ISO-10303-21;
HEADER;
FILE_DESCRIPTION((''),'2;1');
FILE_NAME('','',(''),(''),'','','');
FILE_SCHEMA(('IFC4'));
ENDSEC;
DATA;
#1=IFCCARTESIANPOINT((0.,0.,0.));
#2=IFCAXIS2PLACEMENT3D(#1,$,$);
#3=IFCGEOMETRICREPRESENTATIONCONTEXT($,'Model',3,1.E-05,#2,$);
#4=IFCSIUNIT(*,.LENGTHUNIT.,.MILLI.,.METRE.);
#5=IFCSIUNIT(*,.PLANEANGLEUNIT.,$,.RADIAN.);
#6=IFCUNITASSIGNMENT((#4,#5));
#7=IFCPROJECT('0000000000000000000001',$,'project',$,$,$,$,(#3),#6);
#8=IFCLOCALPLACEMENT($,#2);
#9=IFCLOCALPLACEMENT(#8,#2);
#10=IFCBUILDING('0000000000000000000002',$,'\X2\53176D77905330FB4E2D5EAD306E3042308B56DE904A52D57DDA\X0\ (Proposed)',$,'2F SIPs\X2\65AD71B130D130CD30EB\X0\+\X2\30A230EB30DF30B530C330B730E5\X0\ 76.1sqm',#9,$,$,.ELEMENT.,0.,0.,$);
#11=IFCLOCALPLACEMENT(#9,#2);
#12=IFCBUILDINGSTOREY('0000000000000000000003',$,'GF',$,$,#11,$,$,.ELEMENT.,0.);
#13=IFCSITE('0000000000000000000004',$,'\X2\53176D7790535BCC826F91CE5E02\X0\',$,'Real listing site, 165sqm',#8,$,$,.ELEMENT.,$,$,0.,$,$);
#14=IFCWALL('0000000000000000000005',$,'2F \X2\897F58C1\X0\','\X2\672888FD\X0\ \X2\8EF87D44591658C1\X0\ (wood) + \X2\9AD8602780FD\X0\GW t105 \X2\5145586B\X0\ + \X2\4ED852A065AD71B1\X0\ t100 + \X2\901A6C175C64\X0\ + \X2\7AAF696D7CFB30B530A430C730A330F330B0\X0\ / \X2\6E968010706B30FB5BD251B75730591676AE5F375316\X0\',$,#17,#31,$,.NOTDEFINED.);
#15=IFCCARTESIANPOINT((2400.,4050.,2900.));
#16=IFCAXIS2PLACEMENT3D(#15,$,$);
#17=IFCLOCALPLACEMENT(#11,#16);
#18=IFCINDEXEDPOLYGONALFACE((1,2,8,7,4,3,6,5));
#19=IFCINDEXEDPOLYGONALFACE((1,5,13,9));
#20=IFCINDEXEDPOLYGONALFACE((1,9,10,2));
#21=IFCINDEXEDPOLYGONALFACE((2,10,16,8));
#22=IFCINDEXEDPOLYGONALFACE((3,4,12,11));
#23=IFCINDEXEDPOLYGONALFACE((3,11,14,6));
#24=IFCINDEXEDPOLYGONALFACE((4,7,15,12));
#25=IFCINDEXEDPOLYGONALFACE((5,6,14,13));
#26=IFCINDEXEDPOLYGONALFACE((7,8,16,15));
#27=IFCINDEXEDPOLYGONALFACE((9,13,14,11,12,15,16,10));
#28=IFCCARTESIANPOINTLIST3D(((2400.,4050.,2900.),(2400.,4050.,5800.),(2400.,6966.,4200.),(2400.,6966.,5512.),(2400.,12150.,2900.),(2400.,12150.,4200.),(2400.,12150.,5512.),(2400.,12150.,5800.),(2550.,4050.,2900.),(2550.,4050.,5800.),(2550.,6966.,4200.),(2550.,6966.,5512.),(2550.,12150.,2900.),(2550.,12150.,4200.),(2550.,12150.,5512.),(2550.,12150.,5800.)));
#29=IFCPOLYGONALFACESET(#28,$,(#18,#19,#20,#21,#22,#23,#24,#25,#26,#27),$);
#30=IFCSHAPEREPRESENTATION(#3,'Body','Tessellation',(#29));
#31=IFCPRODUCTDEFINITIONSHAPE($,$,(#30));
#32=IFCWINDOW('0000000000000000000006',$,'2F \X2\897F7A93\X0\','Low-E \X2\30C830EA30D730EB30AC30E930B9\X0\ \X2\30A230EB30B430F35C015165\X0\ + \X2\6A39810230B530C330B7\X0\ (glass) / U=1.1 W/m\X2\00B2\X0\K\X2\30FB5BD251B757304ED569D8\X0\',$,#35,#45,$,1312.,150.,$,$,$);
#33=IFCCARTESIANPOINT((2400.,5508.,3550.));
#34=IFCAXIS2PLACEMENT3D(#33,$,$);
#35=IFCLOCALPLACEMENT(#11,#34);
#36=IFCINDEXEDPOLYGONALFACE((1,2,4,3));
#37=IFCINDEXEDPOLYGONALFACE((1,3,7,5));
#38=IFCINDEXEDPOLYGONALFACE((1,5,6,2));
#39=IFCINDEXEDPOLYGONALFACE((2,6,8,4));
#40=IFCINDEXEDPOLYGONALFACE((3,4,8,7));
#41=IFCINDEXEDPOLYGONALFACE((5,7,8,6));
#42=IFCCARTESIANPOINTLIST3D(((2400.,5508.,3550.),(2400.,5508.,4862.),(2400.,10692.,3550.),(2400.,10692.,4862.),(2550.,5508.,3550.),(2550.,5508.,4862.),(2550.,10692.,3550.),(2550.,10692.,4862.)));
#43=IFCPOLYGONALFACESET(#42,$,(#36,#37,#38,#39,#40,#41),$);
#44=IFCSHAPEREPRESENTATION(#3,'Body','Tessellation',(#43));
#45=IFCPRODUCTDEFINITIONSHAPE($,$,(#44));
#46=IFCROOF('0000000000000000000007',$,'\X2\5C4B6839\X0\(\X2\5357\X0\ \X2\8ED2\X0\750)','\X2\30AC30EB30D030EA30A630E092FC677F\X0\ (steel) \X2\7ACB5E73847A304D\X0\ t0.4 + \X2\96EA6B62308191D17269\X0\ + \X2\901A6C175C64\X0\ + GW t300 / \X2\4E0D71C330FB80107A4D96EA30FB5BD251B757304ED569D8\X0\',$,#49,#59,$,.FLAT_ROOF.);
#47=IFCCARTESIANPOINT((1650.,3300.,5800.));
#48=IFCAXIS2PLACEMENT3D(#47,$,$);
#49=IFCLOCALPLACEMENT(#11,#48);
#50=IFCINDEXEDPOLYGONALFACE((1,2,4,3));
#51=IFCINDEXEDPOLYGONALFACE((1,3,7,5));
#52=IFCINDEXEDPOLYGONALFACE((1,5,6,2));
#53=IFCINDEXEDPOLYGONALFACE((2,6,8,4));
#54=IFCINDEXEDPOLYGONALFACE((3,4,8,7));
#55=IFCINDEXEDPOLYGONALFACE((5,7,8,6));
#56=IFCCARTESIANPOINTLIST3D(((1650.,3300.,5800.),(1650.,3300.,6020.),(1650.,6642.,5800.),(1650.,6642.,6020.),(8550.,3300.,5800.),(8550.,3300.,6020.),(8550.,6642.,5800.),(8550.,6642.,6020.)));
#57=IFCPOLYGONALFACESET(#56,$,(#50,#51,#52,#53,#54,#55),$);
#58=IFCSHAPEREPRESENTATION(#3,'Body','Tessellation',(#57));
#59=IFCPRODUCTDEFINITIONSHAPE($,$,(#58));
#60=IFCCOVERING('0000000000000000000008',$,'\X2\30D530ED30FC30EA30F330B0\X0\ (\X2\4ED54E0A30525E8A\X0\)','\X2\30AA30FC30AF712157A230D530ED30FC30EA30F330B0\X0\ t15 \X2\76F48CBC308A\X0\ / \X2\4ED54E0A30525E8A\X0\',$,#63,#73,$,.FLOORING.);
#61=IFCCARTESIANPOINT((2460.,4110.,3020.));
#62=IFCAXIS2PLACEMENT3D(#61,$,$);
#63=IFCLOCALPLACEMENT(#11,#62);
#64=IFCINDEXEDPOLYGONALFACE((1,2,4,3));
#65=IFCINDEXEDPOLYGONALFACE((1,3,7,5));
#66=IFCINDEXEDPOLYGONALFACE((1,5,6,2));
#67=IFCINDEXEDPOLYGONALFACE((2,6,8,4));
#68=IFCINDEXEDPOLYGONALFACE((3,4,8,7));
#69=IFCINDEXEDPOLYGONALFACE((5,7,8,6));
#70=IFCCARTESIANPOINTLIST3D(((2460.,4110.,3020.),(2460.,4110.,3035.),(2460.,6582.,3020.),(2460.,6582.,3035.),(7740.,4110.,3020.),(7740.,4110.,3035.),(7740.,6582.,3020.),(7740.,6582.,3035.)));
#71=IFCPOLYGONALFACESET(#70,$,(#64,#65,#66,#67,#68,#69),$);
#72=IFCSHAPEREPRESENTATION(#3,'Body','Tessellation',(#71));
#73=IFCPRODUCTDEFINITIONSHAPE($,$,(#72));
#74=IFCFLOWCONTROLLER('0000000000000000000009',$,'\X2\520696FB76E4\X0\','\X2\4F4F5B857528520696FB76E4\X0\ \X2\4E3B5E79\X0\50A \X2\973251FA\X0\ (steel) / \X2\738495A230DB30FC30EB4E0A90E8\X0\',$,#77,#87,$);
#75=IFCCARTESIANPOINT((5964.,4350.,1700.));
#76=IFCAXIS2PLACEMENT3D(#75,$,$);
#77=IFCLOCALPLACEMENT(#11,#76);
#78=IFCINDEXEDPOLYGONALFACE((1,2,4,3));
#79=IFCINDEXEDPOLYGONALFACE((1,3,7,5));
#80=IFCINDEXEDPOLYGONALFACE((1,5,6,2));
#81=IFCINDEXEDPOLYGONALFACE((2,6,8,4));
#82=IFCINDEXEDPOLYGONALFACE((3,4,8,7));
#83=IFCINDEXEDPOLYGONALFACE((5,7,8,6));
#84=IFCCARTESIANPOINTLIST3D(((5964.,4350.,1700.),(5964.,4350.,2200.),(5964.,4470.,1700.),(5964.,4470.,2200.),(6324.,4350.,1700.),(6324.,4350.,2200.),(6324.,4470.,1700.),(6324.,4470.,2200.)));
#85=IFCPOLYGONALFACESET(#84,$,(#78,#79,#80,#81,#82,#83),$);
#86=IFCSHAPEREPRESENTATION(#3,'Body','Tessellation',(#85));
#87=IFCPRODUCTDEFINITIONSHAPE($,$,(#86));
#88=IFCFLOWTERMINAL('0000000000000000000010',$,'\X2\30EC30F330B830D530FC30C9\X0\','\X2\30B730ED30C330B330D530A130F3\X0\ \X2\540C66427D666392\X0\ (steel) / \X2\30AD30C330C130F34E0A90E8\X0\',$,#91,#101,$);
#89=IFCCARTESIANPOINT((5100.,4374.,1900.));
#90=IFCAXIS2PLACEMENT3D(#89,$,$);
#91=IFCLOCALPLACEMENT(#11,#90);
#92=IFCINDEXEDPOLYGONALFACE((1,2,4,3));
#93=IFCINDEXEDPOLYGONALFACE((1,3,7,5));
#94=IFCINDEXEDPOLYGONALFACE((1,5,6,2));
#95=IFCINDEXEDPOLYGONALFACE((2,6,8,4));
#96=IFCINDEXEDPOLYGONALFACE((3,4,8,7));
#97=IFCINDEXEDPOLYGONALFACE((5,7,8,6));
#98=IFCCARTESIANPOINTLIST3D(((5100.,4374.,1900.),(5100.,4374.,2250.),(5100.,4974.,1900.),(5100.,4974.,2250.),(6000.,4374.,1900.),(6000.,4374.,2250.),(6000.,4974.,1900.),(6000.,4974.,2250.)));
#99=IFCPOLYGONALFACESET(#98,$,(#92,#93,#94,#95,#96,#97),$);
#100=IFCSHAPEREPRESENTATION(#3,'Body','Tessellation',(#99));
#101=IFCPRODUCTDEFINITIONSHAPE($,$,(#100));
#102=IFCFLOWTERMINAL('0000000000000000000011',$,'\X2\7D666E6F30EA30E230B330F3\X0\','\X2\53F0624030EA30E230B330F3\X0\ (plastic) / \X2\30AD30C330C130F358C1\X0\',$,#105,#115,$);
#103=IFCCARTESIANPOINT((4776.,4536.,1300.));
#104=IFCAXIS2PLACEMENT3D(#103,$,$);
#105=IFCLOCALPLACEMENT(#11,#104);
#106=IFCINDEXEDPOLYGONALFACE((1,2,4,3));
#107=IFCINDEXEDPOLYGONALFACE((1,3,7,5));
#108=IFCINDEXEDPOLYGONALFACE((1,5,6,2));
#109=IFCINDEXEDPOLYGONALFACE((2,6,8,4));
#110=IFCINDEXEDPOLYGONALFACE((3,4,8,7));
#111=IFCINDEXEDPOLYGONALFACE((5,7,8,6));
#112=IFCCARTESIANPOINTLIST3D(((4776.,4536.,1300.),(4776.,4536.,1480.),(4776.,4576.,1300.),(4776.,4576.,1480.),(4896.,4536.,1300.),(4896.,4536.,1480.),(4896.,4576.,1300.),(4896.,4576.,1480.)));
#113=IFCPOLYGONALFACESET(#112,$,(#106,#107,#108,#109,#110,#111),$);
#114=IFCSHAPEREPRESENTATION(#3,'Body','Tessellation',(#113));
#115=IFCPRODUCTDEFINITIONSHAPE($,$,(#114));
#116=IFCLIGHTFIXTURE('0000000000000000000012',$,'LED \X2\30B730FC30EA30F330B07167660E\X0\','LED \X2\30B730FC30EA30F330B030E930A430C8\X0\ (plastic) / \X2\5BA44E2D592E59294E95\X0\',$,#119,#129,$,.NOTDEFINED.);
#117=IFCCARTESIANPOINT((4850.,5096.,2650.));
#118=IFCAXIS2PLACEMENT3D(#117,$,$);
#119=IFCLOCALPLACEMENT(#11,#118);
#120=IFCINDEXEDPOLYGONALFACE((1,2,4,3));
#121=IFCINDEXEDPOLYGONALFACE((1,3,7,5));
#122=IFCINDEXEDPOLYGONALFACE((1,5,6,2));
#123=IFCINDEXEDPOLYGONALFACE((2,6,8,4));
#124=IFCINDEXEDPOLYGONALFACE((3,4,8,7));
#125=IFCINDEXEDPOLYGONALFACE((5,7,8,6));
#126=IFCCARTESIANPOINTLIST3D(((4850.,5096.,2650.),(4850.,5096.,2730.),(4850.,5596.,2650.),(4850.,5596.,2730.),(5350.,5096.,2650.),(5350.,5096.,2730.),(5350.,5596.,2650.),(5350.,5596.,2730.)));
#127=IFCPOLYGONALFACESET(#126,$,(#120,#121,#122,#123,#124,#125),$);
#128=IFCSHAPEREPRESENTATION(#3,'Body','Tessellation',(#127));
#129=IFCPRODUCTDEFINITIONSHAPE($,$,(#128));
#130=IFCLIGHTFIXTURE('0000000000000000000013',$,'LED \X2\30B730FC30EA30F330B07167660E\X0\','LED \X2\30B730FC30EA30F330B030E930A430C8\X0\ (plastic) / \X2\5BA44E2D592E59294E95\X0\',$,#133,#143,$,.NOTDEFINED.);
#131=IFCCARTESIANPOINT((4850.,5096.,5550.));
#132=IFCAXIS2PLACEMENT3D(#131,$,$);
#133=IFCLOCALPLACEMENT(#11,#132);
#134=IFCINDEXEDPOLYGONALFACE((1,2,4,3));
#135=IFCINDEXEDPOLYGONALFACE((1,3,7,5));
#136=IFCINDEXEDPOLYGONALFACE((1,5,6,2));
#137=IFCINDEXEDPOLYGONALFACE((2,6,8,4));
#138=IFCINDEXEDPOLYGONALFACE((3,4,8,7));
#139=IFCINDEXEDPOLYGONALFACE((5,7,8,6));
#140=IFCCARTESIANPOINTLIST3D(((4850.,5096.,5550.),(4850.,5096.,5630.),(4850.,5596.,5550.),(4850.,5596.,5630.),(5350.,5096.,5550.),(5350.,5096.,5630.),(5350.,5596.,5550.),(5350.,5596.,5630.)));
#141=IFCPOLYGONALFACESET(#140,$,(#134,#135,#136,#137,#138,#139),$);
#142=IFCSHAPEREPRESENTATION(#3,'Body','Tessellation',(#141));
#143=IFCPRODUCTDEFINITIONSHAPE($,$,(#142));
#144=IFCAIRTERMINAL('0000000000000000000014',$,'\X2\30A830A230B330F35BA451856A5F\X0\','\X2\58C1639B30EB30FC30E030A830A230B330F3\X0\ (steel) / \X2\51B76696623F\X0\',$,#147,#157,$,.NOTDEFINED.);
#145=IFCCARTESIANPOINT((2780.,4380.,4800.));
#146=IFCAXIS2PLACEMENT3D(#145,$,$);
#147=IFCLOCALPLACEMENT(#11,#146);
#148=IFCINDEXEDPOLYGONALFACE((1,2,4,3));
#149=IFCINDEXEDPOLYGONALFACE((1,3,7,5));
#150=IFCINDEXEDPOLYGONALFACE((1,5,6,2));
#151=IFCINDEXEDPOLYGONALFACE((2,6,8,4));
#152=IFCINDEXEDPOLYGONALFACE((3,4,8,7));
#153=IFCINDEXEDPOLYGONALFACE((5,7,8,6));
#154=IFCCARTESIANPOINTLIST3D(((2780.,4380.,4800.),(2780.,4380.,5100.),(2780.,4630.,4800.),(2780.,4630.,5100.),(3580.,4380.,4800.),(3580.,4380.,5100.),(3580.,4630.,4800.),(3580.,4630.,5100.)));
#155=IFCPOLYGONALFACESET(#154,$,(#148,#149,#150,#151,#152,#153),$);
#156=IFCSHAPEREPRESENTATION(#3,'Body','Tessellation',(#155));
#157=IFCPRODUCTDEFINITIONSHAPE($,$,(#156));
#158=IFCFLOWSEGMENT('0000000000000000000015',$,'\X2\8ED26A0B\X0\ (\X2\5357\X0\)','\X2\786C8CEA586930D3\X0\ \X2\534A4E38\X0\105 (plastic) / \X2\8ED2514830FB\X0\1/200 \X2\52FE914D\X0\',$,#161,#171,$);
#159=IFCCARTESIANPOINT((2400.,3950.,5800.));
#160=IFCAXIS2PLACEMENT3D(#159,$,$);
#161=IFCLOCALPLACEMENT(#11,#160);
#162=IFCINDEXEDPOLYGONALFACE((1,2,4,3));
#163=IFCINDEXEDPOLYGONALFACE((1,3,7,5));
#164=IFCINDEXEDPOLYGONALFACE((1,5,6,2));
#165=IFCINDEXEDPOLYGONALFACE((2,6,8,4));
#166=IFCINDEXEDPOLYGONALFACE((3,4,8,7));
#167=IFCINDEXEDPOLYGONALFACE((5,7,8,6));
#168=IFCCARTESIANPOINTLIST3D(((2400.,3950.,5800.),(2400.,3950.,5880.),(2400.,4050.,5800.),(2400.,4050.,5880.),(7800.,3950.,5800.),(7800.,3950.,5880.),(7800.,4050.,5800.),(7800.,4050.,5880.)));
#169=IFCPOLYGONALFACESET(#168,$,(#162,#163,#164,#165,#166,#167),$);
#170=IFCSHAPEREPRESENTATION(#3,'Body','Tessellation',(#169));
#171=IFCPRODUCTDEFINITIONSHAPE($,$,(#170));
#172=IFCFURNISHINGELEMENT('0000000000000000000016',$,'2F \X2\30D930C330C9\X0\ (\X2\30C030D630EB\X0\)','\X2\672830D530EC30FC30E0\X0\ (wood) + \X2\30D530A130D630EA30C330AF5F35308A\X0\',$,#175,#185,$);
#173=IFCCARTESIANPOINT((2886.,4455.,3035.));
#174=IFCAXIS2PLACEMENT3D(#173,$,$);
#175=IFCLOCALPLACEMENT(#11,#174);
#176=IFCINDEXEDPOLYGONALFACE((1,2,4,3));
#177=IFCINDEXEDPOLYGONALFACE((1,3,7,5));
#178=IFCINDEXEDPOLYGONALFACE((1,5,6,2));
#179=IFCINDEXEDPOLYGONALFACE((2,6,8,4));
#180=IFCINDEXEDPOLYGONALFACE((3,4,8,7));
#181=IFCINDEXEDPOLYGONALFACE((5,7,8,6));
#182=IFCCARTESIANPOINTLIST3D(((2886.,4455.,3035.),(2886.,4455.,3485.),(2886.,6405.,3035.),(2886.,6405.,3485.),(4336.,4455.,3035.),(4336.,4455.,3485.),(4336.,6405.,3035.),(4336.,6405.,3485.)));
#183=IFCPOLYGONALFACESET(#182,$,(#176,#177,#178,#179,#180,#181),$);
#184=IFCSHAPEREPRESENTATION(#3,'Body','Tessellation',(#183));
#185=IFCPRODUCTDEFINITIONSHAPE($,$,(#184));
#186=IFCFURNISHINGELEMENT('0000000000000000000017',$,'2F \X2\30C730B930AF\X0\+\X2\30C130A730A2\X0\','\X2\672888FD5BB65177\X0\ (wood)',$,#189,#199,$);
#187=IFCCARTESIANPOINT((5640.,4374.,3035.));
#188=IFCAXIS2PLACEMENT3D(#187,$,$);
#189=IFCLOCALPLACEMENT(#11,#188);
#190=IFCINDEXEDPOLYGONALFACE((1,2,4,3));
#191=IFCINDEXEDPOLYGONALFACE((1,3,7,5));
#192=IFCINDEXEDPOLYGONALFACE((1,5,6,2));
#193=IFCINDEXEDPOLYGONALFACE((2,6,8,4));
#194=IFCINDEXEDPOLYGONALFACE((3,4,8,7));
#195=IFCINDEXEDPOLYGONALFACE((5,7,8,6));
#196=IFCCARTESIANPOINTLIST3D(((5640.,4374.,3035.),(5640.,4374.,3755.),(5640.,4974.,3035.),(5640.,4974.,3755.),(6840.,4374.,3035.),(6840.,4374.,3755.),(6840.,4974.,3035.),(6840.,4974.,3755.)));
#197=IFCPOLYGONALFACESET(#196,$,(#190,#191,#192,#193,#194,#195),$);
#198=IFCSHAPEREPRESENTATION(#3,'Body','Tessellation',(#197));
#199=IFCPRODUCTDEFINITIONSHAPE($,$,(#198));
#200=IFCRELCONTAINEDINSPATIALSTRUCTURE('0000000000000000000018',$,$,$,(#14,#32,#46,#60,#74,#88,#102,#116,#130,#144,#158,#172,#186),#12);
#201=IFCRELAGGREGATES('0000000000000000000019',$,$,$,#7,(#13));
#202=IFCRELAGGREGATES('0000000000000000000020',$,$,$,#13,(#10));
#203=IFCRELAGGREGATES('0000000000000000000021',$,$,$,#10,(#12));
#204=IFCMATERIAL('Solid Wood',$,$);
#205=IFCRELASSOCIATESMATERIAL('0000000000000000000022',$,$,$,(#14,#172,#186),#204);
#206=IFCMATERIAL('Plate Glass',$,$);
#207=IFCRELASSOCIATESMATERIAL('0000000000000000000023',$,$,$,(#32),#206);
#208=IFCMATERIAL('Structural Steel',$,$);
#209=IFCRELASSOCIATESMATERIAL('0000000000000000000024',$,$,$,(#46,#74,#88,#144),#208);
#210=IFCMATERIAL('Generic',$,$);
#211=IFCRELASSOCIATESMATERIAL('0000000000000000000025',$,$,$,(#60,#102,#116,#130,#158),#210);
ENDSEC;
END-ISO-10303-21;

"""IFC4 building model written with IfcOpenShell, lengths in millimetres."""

from ifc_helpers import new_model, si_unit, frame, frame_2d, origin, place, context, project, spatial, rectangle, extrude, material, element, fill, save


model = new_model("IFC4")

# Units and contexts
model_context = context("Model", 3, precision=1e-05, world=origin())
ifc_project = project(units=[si_unit("LENGTHUNIT", "METRE", prefix="MILLI"), si_unit("PLANEANGLEUNIT", "RADIAN")], contexts=[model_context])

# Site, building, storey
site_placement = place(None, origin())
site = spatial("IfcSite", under=ifc_project, at=site_placement, Name="北海道富良野市", ObjectType="Real listing site, 165sqm", CompositionType="ELEMENT", RefElevation=0.0)
building_placement = place(site_placement, origin())
building = spatial("IfcBuilding", under=site, at=building_placement, Name="北海道・中庭のある回遊動線 (Proposed)", ObjectType="2F SIPs断熱パネル+アルミサッシュ 76.1sqm", CompositionType="ELEMENT", ElevationOfRefHeight=0.0, ElevationOfTerrain=0.0)
storey_placement = place(building_placement, origin())
storey = spatial("IfcBuildingStorey", under=building, at=storey_placement, Name="GF", CompositionType="ELEMENT", Elevation=0.0)

# Shared definitions
ifc_material_1 = material(Name="Solid Wood")

# Wall, opening, window
ifc_material_2 = material(Name="Plate Glass")
wall_1_placement = place(storey_placement, frame((2400.0, 4050.0, 2900.0)))
wall_1 = element("IfcWall", 1, at=wall_1_placement, inside=storey, material=ifc_material_1, Name="2F 西壁", Description="木製 軸組外壁 (wood) + 高性能GW t105 充填 + 付加断熱 t100 + 通気層 + 窯業系サイディング / 準耐火・寒冷地外皮強化", PredefinedType="NOTDEFINED", context=model_context, shape_type="SweptSolid", body=[
    extrude(rectangle(XDim=150.0, YDim=8100.0, at=frame_2d((75.0, 4050.0))), frame((2400.0, 4050.0, 2900.0)), (0.0, 0.0, 1.0), 2900.0),
])
opening_1_placement = place(storey_placement, frame((2400.0, 5508.0, 3550.0)))
opening_1 = element("IfcOpeningElement", 2, at=opening_1_placement, cuts=wall_1, PredefinedType="NOTDEFINED", context=model_context, shape_type="SweptSolid", body=[
    extrude(rectangle(XDim=150.0, YDim=5184.0, at=frame_2d((75.0, 2592.0))), frame((2400.0, 5508.0, 3550.0)), (0.0, 0.0, 1.0), 1312.0),
])
window_1_placement = place(storey_placement, frame((2400.0, 5508.0, 3550.0)))
window_1 = element("IfcWindow", 3, at=window_1_placement, inside=storey, material=ifc_material_2, Name="2F 西窓", Description="Low-E トリプルガラス アルゴン封入 + 樹脂サッシ (glass) / U=1.1 W/m²K・寒冷地仕様", OverallHeight=1312.0, OverallWidth=150.0, context=model_context, shape_type="SweptSolid", body=[
    extrude(rectangle(XDim=150.0, YDim=5184.0, at=frame_2d((75.0, 2592.0))), frame((2400.0, 5508.0, 3550.0)), (0.0, 0.0, 1.0), 1312.0),
])
fill(opening_1, window_1)

# Roof
ifc_material_3 = material(Name="Structural Steel")
for number, where, name in (
    (4, (1650.0, 3300.0, 5800.0), "屋根(南 軒750)"),
):
    element("IfcRoof", number, at=place(storey_placement, frame(where)), inside=storey, material=ifc_material_3, Name=name, Description="ガルバリウム鋼板 (steel) 立平葺き t0.4 + 雪止め金物 + 通気層 + GW t300 / 不燃・耐積雪・寒冷地仕様", PredefinedType="FLAT_ROOF", context=model_context, shape_type="SweptSolid", body=[
        extrude(rectangle(XDim=6900.0, YDim=3342.0, at=frame_2d((3450.0, 1671.0))), frame((1650.0, 3300.0, 5800.0)), (0.0, 0.0, 1.0), 220.0),
    ])

# Covering
ifc_material_4 = material(Name="Generic")
covering_placement = place(storey_placement, frame((2460.0, 4110.0, 3020.0)))
element("IfcCovering", 5, at=covering_placement, inside=storey, material=ifc_material_4, Name="フローリング (仕上げ床)", Description="オーク無垢フローリング t15 直貼り / 仕上げ床", PredefinedType="FLOORING", context=model_context, shape_type="SweptSolid", body=[
    extrude(rectangle(XDim=5280.0, YDim=2472.0, at=frame_2d((2640.0, 1236.0))), frame((2460.0, 4110.0, 3020.0)), (0.0, 0.0, 1.0), 15.0),
])

# Flow controller
flow_controller_placement = place(storey_placement, frame((5964.0, 4350.0, 1700.0)))
element("IfcFlowController", 6, at=flow_controller_placement, inside=storey, material=ifc_material_3, Name="分電盤", Description="住宅用分電盤 主幹50A 露出 (steel) / 玄関ホール上部", context=model_context, shape_type="SweptSolid", body=[
    extrude(rectangle(XDim=360.0, YDim=120.0, at=frame_2d((180.0, 60.0))), frame((5964.0, 4350.0, 1700.0)), (0.0, 0.0, 1.0), 500.0),
])

# Flow terminals
flow_terminal_1_placement = place(storey_placement, frame((5100.0, 4374.0, 1900.0)))
element("IfcFlowTerminal", 7, at=flow_terminal_1_placement, inside=storey, material=ifc_material_3, Name="レンジフード", Description="シロッコファン 同時給排 (steel) / キッチン上部", context=model_context, shape_type="SweptSolid", body=[
    extrude(rectangle(XDim=900.0, YDim=600.0, at=frame_2d((450.0, 300.0))), frame((5100.0, 4374.0, 1900.0)), (0.0, 0.0, 1.0), 350.0),
])
flow_terminal_2_placement = place(storey_placement, frame((4776.0, 4536.0, 1300.0)))
element("IfcFlowTerminal", 8, at=flow_terminal_2_placement, inside=storey, material=ifc_material_4, Name="給湯リモコン", Description="台所リモコン (plastic) / キッチン壁", context=model_context, shape_type="SweptSolid", body=[
    extrude(rectangle(XDim=120.0, YDim=40.0, at=frame_2d((60.0, 20.0))), frame((4776.0, 4536.0, 1300.0)), (0.0, 0.0, 1.0), 180.0),
])

# Light fixtures
light_fixture_1_placement = place(storey_placement, frame((4850.0, 5096.0, 2650.0)))
element("IfcLightFixture", 9, at=light_fixture_1_placement, inside=storey, material=ifc_material_4, Name="LED シーリング照明", Description="LED シーリングライト (plastic) / 室中央天井", PredefinedType="NOTDEFINED", context=model_context, shape_type="SweptSolid", body=[
    extrude(rectangle(XDim=500.0, YDim=500.0, at=frame_2d((250.0, 250.0))), frame((4850.0, 5096.0, 2650.0)), (0.0, 0.0, 1.0), 80.0),
])
light_fixture_2_placement = place(storey_placement, frame((4850.0, 5096.0, 5550.0)))
element("IfcLightFixture", 10, at=light_fixture_2_placement, inside=storey, material=ifc_material_4, Name="LED シーリング照明", Description="LED シーリングライト (plastic) / 室中央天井", PredefinedType="NOTDEFINED", context=model_context, shape_type="SweptSolid", body=[
    extrude(rectangle(XDim=500.0, YDim=500.0, at=frame_2d((250.0, 250.0))), frame((4850.0, 5096.0, 5550.0)), (0.0, 0.0, 1.0), 80.0),
])

# Air terminal
air_terminal_placement = place(storey_placement, frame((2780.0, 4380.0, 4800.0)))
element("IfcAirTerminal", 11, at=air_terminal_placement, inside=storey, material=ifc_material_3, Name="エアコン室内機", Description="壁掛ルームエアコン (steel) / 冷暖房", PredefinedType="NOTDEFINED", context=model_context, shape_type="SweptSolid", body=[
    extrude(rectangle(XDim=800.0, YDim=250.0, at=frame_2d((400.0, 125.0))), frame((2780.0, 4380.0, 4800.0)), (0.0, 0.0, 1.0), 300.0),
])

# Flow segment
flow_segment_placement = place(storey_placement, frame((2400.0, 3950.0, 5800.0)))
element("IfcFlowSegment", 12, at=flow_segment_placement, inside=storey, material=ifc_material_4, Name="軒樋 (南)", Description="硬質塩ビ 半丸105 (plastic) / 軒先・1/200 勾配", context=model_context, shape_type="SweptSolid", body=[
    extrude(rectangle(XDim=5400.0, YDim=100.0, at=frame_2d((2700.0, 50.0))), frame((2400.0, 3950.0, 5800.0)), (0.0, 0.0, 1.0), 80.0),
])

# Furnishing elements
furnishing_1_placement = place(storey_placement, frame((2886.0, 4455.0, 3035.0)))
element("IfcFurnishingElement", 13, at=furnishing_1_placement, inside=storey, material=ifc_material_1, Name="2F ベッド (ダブル)", Description="木フレーム (wood) + ファブリック張り", context=model_context, shape_type="SweptSolid", body=[
    extrude(rectangle(XDim=1450.0, YDim=1950.0, at=frame_2d((725.0, 975.0))), frame((2886.0, 4455.0, 3035.0)), (0.0, 0.0, 1.0), 450.0),
])
furnishing_2_placement = place(storey_placement, frame((5640.0, 4374.0, 3035.0)))
element("IfcFurnishingElement", 14, at=furnishing_2_placement, inside=storey, material=ifc_material_1, Name="2F デスク+チェア", Description="木製家具 (wood)", context=model_context, shape_type="SweptSolid", body=[
    extrude(rectangle(XDim=1200.0, YDim=600.0, at=frame_2d((600.0, 300.0))), frame((5640.0, 4374.0, 3035.0)), (0.0, 0.0, 1.0), 720.0),
])

save(model, "model.ifc")
